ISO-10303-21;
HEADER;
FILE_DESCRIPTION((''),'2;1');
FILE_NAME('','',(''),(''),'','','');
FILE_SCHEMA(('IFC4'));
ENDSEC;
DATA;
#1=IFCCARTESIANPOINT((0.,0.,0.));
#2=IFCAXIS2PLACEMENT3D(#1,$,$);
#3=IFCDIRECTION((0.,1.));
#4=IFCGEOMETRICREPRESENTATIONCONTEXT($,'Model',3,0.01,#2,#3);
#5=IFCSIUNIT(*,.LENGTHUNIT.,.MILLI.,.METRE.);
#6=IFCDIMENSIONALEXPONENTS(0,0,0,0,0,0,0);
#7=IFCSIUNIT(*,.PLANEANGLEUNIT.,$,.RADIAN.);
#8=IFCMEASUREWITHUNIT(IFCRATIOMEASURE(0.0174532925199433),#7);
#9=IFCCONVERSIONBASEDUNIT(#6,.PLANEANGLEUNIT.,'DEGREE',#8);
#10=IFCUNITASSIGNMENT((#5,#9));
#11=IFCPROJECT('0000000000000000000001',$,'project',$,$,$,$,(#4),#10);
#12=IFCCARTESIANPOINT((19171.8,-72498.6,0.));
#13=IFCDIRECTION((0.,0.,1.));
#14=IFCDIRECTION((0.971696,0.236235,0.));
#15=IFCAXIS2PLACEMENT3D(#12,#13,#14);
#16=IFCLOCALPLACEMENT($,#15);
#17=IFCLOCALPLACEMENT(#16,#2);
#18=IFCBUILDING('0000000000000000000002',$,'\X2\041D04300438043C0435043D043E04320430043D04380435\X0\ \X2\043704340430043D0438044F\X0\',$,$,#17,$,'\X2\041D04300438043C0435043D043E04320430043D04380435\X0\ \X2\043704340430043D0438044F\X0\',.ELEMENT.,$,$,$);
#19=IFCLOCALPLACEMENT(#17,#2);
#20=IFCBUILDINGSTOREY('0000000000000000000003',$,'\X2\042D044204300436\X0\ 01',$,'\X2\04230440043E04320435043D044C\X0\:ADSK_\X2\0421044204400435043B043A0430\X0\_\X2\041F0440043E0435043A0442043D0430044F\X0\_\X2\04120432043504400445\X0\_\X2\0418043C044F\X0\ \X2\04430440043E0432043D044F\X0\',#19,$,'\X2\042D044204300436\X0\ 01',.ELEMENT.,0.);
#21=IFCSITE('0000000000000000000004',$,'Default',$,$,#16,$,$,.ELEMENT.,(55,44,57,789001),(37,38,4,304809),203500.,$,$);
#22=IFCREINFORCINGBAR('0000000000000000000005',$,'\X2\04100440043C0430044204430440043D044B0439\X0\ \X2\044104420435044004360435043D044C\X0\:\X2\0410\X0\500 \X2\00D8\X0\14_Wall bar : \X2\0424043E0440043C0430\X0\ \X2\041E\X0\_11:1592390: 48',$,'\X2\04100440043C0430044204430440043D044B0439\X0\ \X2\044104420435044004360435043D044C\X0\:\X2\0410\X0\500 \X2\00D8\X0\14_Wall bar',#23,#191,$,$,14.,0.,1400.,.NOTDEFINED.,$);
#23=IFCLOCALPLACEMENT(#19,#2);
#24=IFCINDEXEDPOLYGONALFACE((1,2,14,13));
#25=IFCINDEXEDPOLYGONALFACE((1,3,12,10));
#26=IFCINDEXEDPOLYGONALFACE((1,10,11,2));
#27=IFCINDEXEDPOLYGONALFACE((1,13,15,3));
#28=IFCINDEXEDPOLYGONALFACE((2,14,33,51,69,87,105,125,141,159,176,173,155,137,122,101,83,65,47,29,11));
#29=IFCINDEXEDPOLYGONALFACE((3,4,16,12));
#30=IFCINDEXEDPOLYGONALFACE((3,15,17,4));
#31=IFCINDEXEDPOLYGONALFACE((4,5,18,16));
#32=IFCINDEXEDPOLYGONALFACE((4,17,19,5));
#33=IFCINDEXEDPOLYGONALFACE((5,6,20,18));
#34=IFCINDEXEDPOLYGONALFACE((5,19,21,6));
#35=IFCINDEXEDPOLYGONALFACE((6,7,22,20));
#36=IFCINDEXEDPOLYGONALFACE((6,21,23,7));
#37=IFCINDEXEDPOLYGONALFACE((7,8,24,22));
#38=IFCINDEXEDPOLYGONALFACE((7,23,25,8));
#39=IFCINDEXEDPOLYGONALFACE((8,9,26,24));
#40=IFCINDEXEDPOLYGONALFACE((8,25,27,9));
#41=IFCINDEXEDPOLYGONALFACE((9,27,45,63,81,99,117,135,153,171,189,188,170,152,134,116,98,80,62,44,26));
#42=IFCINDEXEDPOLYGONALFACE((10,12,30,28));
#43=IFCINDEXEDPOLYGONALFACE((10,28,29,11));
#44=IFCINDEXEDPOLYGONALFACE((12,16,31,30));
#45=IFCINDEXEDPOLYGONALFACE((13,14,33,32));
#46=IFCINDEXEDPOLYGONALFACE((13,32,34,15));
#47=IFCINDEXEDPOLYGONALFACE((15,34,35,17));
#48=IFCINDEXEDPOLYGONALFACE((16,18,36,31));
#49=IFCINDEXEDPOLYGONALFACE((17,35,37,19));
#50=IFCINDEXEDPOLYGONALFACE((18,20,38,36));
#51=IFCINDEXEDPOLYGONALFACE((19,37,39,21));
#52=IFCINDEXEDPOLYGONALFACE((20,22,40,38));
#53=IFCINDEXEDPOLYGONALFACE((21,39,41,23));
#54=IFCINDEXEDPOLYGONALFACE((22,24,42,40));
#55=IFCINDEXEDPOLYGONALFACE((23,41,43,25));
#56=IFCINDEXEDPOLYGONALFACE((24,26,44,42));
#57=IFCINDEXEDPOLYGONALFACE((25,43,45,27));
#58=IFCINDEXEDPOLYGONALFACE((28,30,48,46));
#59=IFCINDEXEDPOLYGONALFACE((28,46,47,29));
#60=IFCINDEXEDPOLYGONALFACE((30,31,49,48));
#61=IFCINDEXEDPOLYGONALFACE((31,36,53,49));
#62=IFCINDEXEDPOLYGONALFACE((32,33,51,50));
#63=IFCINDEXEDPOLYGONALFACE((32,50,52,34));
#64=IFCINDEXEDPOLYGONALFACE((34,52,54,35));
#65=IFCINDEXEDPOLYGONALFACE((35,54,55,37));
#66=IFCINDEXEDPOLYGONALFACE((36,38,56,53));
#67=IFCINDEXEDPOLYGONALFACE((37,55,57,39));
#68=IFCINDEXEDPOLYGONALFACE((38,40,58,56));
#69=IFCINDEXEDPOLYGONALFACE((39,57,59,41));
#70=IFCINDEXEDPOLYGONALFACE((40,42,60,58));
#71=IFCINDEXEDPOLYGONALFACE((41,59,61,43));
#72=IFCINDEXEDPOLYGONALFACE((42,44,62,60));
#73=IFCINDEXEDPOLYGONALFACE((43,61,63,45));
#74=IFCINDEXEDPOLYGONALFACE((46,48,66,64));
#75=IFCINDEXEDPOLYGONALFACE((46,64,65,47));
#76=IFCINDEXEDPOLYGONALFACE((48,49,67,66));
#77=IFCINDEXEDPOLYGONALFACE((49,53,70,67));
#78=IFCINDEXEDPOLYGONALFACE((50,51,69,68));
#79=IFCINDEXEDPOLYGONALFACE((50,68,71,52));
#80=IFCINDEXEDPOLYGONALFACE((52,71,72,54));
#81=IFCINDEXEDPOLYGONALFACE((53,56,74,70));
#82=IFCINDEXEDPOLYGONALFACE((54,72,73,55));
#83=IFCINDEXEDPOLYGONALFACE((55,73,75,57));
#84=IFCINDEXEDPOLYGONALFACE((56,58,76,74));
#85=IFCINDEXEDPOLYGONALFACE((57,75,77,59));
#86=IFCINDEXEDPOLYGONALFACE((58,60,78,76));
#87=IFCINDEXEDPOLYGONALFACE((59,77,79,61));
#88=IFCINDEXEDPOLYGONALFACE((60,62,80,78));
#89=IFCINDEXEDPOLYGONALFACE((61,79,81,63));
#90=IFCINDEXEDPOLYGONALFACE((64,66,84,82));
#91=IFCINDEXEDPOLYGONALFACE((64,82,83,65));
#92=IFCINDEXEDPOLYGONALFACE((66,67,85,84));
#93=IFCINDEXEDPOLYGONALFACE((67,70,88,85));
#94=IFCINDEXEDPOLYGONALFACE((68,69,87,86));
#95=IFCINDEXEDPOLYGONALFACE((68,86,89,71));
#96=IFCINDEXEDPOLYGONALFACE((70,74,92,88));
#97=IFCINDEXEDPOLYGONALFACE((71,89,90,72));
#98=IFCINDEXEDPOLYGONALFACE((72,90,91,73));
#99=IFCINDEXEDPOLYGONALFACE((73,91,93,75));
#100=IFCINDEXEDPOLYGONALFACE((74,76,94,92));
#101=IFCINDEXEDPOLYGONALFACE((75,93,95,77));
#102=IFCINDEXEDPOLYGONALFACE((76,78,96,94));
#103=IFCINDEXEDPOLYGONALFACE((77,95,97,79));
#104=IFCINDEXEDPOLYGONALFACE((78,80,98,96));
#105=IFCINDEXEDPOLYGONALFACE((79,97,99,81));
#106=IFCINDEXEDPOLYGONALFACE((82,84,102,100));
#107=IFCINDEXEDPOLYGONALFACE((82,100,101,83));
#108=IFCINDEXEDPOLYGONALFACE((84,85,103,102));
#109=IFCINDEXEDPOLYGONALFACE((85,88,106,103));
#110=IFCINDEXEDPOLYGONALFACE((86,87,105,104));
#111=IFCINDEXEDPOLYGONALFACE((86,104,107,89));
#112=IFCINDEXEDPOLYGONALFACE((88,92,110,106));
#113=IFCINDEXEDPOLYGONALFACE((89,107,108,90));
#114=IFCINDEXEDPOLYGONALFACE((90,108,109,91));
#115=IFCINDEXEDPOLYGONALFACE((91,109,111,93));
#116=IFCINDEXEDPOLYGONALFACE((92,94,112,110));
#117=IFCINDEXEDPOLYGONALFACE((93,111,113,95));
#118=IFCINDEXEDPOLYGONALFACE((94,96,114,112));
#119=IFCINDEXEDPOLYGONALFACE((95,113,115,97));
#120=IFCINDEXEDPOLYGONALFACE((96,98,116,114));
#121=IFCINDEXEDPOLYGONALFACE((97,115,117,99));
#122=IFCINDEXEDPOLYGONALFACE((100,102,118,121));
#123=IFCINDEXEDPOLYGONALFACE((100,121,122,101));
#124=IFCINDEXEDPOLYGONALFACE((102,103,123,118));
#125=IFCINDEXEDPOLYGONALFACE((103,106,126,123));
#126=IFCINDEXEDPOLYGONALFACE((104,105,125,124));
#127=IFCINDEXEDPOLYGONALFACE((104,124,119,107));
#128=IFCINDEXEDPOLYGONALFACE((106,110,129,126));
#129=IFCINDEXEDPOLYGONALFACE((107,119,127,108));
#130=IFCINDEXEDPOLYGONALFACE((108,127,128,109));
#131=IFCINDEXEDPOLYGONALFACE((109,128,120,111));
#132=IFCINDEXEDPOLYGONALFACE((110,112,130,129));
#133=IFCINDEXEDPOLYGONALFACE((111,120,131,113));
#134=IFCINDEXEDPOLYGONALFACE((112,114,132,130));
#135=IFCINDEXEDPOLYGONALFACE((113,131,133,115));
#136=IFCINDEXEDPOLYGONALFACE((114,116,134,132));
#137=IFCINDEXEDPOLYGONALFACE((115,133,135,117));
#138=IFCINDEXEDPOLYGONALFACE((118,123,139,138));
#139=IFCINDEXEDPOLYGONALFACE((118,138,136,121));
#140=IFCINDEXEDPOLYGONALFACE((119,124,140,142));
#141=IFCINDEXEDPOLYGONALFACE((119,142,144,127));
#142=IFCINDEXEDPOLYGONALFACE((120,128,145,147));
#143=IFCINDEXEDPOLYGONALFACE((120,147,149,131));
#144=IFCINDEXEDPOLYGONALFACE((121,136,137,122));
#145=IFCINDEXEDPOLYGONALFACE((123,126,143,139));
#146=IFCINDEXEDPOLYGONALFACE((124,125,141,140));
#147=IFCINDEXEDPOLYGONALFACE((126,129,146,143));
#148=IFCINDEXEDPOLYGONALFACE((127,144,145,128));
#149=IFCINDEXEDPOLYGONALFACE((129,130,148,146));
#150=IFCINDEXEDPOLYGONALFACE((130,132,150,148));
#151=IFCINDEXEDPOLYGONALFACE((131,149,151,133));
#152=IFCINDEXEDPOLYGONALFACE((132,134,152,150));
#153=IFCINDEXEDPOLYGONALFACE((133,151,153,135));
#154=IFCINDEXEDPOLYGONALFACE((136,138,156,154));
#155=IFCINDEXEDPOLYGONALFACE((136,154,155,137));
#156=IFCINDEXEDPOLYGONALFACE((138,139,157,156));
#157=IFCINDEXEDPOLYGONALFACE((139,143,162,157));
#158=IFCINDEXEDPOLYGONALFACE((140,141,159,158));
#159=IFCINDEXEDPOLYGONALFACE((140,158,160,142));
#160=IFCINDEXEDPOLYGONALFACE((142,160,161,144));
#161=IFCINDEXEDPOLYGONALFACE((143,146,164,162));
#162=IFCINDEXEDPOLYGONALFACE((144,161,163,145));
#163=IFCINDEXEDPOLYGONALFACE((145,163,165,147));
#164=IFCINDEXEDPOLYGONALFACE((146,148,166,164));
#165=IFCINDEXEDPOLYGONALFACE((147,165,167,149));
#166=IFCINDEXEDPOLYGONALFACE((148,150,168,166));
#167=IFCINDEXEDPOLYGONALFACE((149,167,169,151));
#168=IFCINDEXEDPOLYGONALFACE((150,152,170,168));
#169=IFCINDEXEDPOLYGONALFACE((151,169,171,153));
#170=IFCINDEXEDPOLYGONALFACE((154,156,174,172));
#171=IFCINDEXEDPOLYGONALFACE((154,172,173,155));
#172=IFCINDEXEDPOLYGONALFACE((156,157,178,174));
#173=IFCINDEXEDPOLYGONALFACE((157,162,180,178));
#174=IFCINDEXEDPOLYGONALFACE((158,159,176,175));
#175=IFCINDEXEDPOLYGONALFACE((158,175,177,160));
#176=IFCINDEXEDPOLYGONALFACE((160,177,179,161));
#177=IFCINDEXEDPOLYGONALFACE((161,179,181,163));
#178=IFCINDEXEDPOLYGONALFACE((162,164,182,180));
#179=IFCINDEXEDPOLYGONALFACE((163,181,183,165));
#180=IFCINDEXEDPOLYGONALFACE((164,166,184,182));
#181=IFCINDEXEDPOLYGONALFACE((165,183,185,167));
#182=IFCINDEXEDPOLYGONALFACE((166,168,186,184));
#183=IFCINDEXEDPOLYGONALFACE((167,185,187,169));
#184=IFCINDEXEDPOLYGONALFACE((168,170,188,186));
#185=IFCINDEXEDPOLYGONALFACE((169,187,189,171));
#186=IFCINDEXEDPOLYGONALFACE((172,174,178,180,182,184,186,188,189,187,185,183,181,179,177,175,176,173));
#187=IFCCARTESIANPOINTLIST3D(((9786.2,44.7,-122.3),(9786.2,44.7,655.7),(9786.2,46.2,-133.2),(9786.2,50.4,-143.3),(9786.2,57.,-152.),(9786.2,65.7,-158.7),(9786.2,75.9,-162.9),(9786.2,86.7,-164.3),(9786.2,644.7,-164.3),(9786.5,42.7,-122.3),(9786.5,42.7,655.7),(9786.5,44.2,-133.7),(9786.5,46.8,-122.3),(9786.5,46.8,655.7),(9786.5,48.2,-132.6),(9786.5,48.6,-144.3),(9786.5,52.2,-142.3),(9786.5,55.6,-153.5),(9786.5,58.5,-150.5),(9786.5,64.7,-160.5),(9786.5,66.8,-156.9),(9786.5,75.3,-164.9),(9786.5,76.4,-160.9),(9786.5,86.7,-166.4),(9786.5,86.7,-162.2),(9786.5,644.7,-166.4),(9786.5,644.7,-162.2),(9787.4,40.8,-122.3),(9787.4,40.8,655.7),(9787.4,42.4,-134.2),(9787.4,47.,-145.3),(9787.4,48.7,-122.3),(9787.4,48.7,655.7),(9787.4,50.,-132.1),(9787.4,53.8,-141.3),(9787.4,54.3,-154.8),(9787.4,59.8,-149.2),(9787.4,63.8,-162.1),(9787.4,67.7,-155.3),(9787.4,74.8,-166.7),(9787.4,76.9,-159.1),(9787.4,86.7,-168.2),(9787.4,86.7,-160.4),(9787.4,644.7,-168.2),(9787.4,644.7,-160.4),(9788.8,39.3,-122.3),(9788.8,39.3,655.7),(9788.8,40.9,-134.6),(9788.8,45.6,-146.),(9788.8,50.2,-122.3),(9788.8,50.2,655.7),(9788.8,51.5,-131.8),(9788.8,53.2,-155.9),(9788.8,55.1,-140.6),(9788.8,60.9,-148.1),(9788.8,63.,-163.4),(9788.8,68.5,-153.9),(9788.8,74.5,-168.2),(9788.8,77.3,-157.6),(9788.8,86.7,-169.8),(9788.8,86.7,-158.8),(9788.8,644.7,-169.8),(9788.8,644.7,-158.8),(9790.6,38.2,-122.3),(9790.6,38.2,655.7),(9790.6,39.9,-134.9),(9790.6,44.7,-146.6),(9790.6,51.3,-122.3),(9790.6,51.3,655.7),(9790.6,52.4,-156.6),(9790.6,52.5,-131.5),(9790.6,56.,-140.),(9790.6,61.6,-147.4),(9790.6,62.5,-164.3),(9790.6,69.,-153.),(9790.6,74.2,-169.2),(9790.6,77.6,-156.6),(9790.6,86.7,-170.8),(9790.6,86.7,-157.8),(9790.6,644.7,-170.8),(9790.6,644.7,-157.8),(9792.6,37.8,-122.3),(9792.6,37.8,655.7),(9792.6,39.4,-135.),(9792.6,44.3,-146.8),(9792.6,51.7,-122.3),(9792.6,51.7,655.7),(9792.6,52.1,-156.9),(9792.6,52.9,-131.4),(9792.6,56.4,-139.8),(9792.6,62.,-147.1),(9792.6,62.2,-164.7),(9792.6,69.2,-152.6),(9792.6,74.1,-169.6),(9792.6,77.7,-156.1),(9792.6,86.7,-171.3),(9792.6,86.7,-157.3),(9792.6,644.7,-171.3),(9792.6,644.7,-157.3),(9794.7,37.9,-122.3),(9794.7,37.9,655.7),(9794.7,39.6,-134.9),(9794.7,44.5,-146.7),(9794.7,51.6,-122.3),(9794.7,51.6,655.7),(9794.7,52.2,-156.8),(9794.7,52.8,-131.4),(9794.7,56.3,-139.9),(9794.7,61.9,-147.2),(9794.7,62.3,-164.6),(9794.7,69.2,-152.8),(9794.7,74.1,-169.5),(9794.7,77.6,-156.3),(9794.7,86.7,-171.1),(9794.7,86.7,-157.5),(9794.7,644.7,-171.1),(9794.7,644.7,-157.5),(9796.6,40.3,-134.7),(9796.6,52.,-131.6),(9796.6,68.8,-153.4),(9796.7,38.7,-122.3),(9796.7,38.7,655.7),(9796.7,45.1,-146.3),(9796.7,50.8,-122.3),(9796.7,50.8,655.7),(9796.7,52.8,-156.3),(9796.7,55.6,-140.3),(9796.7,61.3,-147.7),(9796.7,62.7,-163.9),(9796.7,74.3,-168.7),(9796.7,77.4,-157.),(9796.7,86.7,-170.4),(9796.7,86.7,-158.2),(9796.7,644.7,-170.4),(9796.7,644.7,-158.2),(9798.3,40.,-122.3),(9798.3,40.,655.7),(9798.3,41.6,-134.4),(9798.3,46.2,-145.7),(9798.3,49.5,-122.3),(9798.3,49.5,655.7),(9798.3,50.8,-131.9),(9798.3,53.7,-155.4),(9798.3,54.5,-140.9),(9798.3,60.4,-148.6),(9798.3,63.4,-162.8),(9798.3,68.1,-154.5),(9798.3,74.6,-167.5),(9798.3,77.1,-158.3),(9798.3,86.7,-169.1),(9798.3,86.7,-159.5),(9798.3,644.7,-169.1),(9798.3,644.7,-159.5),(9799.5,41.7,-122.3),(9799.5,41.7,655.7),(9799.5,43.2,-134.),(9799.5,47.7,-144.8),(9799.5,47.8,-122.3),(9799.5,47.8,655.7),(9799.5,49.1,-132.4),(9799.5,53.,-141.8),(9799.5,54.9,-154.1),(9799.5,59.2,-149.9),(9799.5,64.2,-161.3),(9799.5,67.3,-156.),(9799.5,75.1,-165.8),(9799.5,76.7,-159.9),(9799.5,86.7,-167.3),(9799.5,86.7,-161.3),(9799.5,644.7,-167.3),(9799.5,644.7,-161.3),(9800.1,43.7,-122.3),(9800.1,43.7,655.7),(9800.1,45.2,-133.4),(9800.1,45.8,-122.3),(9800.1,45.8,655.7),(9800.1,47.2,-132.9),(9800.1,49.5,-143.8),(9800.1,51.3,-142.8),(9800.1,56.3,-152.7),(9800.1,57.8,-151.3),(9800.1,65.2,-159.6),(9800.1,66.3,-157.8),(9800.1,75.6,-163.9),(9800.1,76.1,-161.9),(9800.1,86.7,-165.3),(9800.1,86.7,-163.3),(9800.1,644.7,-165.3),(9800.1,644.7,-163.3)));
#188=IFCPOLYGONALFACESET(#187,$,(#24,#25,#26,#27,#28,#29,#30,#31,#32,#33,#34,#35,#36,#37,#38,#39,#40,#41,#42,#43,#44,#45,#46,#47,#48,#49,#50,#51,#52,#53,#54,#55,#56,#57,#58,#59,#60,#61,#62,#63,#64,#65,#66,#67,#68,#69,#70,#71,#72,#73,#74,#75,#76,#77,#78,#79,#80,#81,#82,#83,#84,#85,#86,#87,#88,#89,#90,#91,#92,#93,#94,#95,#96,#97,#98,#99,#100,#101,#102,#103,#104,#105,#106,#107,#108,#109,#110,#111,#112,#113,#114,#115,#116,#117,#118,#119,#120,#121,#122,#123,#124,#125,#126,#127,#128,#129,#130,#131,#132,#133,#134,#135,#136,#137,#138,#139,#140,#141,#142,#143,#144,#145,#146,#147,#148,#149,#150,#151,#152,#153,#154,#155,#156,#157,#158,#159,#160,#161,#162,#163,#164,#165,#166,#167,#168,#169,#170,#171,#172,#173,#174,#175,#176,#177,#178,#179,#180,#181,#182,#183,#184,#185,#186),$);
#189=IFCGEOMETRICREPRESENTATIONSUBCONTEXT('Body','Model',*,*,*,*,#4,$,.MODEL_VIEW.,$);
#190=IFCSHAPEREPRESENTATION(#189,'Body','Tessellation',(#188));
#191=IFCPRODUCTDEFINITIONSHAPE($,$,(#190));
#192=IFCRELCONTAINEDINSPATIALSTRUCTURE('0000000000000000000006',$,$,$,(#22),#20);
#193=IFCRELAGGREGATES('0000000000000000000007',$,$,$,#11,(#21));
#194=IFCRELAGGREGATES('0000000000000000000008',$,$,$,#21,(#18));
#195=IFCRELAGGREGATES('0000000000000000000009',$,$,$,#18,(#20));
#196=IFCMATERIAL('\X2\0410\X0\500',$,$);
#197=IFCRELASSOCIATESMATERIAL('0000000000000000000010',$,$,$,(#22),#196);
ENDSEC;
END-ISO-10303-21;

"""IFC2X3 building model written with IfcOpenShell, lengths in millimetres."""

from ifc_helpers import new_model, entity, si_unit, converted_unit, direction, frame, origin, place, context, subcontext, project, spatial, material, element, save


model = new_model("IFC2X3")

# Units and contexts
model_context = context("Model", 3, precision=0.01, world=origin(), true_north=direction((0.0, 1.0)))
body_context = subcontext(model_context, "Body", "Model", "MODEL_VIEW")
ifc_project = project(units=[si_unit("LENGTHUNIT", "METRE", prefix="MILLI"), converted_unit("PLANEANGLEUNIT", "DEGREE", entity("IfcRatioMeasure", 0.0174532925199433), si_unit("PLANEANGLEUNIT", "RADIAN"), dimensions=[0, 0, 0, 0, 0, 0, 0])], contexts=[model_context])

# Site, building, storey
site_placement = place(None, frame((19171.8, -72498.6, 0.0), z_axis=(0.0, 0.0, 1.0), x_axis=(0.971696, 0.236235, 0.0)))
site = spatial("IfcSite", under=ifc_project, at=site_placement, Name="Default", CompositionType="ELEMENT", RefLatitude=(55, 44, 57, 789001), RefLongitude=(37, 38, 4, 304809), RefElevation=203500.0)
building_placement = place(site_placement, origin())
building = spatial("IfcBuilding", under=site, at=building_placement, Name="Наименование здания", LongName="Наименование здания", CompositionType="ELEMENT")
storey_placement = place(building_placement, origin())
storey = spatial("IfcBuildingStorey", under=building, at=storey_placement, Name="Этаж 01", ObjectType="Уровень:ADSK_Стрелка_Проектная_Вверх_Имя уровня", LongName="Этаж 01", CompositionType="ELEMENT", Elevation=0.0)

# Reinforcing bar
ifc_material = material(Name="А500")
placement = place(storey_placement, origin())
element("IfcReinforcingBar", 1, at=placement, inside=storey, material=ifc_material, Name="Арматурный стержень:А500 Ø14_Wall bar : Форма О_11:1592390: 48", ObjectType="Арматурный стержень:А500 Ø14_Wall bar", BarLength=1400.0, BarRole="NOTDEFINED", CrossSectionArea=0.0, NominalDiameter=14.0, context=body_context, shape_type="AdvancedSweptSolid", body=[
    entity("IfcSweptDiskSolid", entity("IfcCompositeCurve", [entity("IfcCompositeCurveSegment", "CONTINUOUS", True, entity("IfcPolyline", [entity("IfcCartesianPoint", [9793.1, 44.7, 655.7]), entity("IfcCartesianPoint", [9793.1, 44.7, -122.3])])), entity("IfcCompositeCurveSegment", "CONTINUOUS", True, entity("IfcTrimmedCurve", entity("IfcCircle", entity("IfcAxis2Placement3D", entity("IfcCartesianPoint", [9793.1, 86.7, -122.3]), entity("IfcDirection", [1.0, 0.0, 0.0]), entity("IfcDirection", [0.0, 0.0, -1.0])), 42.0), [entity("IfcParameterValue", 270.0)], [entity("IfcParameterValue", 360.0)], True, "PARAMETER")), entity("IfcCompositeCurveSegment", "CONTINUOUS", True, entity("IfcPolyline", [entity("IfcCartesianPoint", [9793.1, 86.7, -164.3]), entity("IfcCartesianPoint", [9793.1, 644.7, -164.3])]))], False), 7.0, None, 0.0, 92.0),
])

save(model, "model.ifc")
